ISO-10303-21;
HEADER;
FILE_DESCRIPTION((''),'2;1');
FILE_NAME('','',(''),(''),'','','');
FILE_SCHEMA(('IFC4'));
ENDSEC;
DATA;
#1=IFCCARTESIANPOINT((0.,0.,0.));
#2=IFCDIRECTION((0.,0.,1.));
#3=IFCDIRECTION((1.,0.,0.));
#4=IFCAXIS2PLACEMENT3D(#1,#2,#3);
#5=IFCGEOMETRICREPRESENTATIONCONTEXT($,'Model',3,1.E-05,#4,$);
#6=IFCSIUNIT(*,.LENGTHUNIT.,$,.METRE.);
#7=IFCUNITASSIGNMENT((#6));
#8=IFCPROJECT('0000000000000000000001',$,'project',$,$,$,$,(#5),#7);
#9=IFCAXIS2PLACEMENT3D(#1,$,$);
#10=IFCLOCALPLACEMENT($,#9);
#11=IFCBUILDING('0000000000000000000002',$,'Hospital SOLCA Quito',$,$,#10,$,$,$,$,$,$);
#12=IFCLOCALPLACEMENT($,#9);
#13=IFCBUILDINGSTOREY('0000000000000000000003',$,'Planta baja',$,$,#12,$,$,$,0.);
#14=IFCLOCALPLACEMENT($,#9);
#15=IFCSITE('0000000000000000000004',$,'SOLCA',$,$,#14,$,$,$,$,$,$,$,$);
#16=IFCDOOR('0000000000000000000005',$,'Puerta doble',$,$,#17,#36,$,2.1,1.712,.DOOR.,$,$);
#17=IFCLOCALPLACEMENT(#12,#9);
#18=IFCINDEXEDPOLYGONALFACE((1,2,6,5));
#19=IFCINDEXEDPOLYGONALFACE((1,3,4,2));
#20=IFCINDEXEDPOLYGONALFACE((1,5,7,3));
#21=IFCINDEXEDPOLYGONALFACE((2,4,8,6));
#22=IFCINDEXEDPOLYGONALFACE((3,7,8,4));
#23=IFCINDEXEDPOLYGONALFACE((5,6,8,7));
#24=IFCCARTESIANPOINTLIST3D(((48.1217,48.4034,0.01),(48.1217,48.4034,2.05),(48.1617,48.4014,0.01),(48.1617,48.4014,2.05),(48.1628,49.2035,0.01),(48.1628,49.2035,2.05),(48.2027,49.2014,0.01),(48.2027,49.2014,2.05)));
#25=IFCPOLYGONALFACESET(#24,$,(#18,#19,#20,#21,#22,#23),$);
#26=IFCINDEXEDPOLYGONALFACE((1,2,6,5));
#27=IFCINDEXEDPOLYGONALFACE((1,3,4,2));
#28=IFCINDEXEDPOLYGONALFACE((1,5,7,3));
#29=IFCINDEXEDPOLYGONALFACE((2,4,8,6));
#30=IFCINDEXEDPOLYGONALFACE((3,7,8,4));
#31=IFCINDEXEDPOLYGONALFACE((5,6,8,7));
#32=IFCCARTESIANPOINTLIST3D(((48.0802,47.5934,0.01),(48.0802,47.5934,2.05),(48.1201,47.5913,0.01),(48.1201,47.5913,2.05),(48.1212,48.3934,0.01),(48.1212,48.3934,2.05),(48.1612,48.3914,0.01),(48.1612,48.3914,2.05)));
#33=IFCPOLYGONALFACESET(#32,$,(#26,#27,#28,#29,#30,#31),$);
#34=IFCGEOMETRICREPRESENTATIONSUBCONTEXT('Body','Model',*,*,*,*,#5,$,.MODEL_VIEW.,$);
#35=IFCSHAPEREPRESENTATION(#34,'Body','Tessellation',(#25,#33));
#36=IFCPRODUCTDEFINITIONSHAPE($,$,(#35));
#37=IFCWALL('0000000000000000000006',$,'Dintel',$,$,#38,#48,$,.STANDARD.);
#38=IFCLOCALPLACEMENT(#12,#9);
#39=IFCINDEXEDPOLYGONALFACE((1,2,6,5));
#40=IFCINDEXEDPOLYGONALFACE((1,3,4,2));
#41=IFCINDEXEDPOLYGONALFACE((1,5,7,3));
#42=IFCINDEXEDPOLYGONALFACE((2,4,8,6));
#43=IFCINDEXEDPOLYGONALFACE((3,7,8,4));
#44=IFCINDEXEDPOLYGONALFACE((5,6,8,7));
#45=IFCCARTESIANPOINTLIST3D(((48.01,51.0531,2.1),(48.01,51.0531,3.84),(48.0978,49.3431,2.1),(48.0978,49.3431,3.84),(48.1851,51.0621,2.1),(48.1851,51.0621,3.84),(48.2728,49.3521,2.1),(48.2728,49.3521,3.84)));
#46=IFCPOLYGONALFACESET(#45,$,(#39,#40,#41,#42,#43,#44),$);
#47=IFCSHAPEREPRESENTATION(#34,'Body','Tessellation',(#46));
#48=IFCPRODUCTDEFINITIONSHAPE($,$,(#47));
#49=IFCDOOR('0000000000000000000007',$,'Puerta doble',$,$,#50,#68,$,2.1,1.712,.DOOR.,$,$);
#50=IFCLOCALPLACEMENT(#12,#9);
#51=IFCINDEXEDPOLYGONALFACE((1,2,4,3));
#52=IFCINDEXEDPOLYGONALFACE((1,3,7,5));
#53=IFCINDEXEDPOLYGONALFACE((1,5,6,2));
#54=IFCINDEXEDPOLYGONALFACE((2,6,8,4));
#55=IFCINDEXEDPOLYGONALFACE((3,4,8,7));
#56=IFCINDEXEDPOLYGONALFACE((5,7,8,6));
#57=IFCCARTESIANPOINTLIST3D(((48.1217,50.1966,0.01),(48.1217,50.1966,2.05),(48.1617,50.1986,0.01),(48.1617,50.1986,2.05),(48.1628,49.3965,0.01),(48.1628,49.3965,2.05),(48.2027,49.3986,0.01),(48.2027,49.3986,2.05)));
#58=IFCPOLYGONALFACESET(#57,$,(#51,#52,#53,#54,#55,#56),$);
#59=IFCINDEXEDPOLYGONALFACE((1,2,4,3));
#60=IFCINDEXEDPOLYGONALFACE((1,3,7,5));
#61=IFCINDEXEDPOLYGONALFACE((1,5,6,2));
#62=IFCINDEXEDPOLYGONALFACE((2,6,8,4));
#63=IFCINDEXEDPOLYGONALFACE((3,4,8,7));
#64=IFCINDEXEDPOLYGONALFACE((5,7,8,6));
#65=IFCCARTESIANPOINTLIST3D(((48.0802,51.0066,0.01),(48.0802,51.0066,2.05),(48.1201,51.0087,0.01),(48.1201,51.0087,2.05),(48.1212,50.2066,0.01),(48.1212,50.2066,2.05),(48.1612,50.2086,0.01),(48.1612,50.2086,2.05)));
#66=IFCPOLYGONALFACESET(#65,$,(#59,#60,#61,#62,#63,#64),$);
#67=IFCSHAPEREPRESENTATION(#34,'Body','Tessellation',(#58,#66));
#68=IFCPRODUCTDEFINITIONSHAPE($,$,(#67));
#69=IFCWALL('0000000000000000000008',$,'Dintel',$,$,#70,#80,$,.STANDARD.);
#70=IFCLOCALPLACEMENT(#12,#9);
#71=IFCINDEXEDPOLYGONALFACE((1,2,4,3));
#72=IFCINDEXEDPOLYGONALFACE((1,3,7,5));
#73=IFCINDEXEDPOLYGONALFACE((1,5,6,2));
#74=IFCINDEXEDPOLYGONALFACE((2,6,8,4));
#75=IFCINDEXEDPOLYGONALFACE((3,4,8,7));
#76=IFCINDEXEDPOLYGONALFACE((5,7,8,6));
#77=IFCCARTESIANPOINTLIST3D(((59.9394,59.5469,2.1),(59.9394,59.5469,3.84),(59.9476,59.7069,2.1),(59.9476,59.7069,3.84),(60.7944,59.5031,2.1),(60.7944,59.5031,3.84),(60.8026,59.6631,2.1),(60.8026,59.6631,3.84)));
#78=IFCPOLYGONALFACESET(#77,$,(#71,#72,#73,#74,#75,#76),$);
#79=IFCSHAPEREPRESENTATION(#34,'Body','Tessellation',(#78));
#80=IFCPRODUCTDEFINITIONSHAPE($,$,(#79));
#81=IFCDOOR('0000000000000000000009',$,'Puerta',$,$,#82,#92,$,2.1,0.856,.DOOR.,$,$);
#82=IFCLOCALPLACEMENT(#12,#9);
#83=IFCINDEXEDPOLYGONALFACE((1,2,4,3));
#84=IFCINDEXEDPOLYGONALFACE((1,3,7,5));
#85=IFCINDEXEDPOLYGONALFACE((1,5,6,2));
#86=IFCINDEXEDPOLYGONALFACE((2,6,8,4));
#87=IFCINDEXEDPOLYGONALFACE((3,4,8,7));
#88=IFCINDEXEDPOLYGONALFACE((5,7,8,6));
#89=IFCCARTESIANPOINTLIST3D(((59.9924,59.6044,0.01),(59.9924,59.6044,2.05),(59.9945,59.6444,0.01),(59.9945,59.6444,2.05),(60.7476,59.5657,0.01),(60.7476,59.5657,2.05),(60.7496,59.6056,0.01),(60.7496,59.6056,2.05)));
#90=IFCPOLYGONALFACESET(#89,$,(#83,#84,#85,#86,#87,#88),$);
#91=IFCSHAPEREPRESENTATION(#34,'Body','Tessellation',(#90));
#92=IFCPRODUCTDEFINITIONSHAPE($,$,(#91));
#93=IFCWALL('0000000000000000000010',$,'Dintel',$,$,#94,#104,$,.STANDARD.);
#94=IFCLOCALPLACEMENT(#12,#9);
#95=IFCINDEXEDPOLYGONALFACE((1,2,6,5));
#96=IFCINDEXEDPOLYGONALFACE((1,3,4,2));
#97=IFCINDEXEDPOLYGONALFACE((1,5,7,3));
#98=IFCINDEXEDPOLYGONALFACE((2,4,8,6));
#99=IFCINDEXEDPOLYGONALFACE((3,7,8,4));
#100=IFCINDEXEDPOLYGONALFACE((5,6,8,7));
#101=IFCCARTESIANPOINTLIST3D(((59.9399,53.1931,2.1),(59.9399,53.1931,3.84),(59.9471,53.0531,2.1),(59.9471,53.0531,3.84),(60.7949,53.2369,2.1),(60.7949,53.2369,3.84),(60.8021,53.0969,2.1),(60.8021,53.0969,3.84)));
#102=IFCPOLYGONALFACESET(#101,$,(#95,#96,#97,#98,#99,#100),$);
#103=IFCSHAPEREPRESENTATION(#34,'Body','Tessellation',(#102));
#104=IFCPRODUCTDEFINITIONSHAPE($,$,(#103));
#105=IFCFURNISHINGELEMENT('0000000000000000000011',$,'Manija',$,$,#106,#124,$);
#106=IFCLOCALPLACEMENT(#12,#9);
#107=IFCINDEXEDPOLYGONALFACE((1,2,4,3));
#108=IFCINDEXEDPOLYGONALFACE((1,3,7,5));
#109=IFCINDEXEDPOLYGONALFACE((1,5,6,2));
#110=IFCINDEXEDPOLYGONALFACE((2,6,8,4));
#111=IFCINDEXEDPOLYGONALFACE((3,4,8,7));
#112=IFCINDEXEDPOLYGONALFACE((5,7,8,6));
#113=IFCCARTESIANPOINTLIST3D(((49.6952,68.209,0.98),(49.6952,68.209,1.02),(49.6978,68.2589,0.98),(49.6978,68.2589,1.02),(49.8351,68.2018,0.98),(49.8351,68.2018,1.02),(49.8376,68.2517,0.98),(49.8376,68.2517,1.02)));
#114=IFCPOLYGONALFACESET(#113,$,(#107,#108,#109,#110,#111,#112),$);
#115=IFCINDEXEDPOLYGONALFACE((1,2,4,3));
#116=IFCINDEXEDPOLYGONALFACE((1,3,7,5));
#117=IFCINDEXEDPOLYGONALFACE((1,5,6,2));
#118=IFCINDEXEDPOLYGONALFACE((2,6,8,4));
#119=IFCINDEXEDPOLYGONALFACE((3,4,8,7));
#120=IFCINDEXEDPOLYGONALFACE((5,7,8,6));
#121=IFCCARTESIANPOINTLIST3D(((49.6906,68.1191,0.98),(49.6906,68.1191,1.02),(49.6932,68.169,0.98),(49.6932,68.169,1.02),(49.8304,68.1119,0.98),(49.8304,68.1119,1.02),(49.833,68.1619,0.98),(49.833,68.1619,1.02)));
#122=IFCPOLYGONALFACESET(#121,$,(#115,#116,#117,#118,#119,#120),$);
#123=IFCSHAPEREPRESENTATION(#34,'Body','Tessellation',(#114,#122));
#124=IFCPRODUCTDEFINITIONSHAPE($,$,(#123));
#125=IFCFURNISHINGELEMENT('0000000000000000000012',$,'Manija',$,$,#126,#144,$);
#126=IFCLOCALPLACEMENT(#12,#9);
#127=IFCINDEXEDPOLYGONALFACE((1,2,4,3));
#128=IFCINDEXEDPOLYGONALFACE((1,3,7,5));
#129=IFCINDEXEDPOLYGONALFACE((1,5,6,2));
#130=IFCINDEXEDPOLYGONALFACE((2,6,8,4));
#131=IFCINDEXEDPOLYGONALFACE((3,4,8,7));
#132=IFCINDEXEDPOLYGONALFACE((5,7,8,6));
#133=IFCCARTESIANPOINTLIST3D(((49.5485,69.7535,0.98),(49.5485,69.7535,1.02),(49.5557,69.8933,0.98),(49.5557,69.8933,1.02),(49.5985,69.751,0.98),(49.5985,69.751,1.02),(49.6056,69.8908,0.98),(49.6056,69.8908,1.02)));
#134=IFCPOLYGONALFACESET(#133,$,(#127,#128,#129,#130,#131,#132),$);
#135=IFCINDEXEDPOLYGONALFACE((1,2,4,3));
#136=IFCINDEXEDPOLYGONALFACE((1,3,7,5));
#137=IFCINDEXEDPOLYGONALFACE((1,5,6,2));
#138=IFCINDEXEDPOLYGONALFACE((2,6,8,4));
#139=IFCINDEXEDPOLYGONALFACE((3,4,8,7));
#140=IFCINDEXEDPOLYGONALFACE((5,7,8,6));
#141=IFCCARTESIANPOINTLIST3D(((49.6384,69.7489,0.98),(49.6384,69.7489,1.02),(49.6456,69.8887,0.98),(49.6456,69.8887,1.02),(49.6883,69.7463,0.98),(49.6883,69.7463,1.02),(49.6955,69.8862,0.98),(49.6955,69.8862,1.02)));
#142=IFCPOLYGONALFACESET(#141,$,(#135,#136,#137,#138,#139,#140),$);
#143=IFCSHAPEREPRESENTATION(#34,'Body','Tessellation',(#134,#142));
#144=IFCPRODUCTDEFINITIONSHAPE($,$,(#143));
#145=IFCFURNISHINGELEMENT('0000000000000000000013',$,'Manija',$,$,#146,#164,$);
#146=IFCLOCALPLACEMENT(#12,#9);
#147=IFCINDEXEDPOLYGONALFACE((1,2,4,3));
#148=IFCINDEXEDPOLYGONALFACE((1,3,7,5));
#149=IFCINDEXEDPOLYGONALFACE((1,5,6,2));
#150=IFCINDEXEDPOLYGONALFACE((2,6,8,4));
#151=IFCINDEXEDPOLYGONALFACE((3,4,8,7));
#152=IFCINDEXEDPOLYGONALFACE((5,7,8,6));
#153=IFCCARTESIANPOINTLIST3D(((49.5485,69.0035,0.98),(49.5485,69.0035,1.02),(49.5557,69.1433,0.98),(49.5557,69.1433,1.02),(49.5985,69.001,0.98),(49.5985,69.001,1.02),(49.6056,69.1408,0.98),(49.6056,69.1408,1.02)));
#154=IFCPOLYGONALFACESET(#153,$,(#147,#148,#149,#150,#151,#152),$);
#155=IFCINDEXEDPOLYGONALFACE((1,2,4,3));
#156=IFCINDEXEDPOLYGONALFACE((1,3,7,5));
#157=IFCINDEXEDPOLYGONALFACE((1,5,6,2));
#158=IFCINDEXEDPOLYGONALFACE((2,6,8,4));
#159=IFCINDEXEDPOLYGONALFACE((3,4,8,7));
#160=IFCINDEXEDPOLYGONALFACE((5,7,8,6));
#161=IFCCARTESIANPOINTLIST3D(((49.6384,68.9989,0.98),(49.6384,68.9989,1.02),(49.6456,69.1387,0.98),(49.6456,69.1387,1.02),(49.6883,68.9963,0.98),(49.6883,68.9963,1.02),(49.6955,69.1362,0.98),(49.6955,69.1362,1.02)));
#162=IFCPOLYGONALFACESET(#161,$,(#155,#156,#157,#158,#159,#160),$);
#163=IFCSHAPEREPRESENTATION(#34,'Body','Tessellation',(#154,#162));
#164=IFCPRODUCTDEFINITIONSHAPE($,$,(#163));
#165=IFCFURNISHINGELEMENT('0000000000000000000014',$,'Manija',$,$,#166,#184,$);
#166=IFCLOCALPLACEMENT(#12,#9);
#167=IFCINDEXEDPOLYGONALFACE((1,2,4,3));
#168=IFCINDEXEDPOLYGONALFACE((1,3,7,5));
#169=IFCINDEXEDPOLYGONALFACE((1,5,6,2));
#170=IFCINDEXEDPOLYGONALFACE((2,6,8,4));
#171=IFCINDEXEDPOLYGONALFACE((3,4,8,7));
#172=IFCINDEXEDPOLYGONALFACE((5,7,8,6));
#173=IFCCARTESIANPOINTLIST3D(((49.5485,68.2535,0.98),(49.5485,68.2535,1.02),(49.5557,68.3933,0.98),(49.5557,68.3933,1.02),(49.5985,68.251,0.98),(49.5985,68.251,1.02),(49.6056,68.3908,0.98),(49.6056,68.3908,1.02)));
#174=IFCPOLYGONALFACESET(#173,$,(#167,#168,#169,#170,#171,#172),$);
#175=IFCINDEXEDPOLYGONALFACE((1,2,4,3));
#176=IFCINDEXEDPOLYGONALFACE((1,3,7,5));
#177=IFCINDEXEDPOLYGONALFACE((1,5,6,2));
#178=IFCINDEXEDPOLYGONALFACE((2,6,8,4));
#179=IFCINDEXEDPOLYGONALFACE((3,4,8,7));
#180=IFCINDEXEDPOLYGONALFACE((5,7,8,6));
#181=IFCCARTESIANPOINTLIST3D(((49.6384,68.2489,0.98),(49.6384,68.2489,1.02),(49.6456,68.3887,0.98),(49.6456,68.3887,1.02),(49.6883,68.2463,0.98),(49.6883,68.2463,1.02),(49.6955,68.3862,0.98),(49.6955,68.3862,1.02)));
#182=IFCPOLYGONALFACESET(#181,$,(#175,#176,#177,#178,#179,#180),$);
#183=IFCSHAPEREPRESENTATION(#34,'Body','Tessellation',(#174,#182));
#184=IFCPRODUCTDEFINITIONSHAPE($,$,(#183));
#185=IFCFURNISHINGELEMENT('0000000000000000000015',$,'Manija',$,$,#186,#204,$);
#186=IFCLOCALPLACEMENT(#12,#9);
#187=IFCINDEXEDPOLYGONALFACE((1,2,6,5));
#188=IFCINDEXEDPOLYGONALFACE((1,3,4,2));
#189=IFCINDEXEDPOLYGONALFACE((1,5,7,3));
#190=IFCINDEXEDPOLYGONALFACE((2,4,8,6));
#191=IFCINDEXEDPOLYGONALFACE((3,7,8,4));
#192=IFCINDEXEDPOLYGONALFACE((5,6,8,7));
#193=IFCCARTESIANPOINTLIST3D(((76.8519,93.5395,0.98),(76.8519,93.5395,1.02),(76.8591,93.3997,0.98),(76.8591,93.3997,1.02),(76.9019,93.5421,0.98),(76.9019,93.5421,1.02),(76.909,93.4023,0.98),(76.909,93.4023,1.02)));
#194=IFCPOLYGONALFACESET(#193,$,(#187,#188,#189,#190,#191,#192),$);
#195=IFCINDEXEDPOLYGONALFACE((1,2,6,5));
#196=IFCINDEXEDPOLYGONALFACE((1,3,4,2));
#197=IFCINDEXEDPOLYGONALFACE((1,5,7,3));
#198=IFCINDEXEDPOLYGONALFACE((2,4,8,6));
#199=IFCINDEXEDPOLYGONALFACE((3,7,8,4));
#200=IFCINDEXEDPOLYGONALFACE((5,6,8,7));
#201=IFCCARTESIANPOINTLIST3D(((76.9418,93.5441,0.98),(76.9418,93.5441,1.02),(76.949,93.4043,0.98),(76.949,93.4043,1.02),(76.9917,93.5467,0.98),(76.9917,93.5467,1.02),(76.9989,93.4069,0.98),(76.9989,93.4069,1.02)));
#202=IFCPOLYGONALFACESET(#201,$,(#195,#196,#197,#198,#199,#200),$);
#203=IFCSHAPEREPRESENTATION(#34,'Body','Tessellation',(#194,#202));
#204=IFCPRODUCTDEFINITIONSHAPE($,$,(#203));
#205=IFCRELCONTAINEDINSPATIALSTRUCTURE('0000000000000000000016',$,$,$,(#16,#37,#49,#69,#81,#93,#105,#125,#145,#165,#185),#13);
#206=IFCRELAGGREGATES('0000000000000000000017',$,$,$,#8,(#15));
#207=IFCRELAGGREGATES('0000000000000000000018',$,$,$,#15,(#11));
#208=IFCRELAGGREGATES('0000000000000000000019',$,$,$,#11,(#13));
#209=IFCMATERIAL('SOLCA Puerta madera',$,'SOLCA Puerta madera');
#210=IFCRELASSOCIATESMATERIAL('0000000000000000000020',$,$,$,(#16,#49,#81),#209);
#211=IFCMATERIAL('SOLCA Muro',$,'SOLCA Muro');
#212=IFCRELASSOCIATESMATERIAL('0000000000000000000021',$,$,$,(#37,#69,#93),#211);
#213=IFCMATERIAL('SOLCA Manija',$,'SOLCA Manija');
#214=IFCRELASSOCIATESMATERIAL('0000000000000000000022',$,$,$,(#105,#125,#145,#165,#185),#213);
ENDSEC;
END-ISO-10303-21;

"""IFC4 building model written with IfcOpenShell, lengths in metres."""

from ifc_helpers import new_model, si_unit, frame, origin, origin_with_axes, place, context, subcontext, project, spatial, polyline, outline, extrude, material, element, save


model = new_model("IFC4")

# Units and contexts
model_context = context("Model", 3, precision=1e-05, world=origin_with_axes())
body_context = subcontext(model_context, "Body", "Model", "MODEL_VIEW")
ifc_project = project(units=[si_unit("LENGTHUNIT", "METRE")], contexts=[model_context])

# Site, building, storey
site_placement = place(None, origin())
site = spatial("IfcSite", under=ifc_project, at=site_placement, Name="SOLCA")
building_placement = place(None, origin())
building = spatial("IfcBuilding", under=site, at=building_placement, Name="Hospital SOLCA Quito")
storey_placement = place(None, origin())
storey = spatial("IfcBuildingStorey", under=building, at=storey_placement, Name="Planta baja", Elevation=0.0)

# Shared definitions
ifc_material_1 = material(Name="SOLCA Muro", Category="SOLCA Muro")

# Shared definitions
ifc_material_2 = material(Name="SOLCA Puerta madera", Category="SOLCA Puerta madera")

# Door
door_1_placement = place(storey_placement, origin_with_axes())
element("IfcDoor", 1, at=door_1_placement, inside=storey, material=ifc_material_2, Name="Puerta doble", OverallHeight=2.1, OverallWidth=1.712, PredefinedType="DOOR", context=body_context, shape_type="SweptSolid", body=[
    extrude(outline(polyline([(48.1628, 49.2035), (48.1217, 48.4034), (48.1617, 48.4014), (48.2027, 49.2014), (48.1628, 49.2035)])), frame((0.0, 0.0, 0.01), z_axis=(0.0, 0.0, 1.0), x_axis=(1.0, 0.0, 0.0)), (0.0, 0.0, 1.0), 2.04),
    extrude(outline(polyline([(48.1212, 48.3934), (48.0802, 47.5934), (48.1201, 47.5913), (48.1612, 48.3914), (48.1212, 48.3934)])), frame((0.0, 0.0, 0.01), z_axis=(0.0, 0.0, 1.0), x_axis=(1.0, 0.0, 0.0)), (0.0, 0.0, 1.0), 2.04),
])

# Wall
wall_1_placement = place(storey_placement, origin_with_axes())
element("IfcWall", 2, at=wall_1_placement, inside=storey, material=ifc_material_1, Name="Dintel", PredefinedType="STANDARD", context=body_context, shape_type="SweptSolid", body=[
    extrude(outline(polyline([(48.2728, 49.3521), (48.1851, 51.0621), (48.01, 51.0531), (48.0978, 49.3431), (48.2728, 49.3521)])), frame((0.0, 0.0, 2.1), z_axis=(0.0, 0.0, 1.0), x_axis=(1.0, 0.0, 0.0)), (0.0, 0.0, 1.0), 1.74),
])

# Door
door_2_placement = place(storey_placement, origin_with_axes())
element("IfcDoor", 3, at=door_2_placement, inside=storey, material=ifc_material_2, Name="Puerta doble", OverallHeight=2.1, OverallWidth=1.712, PredefinedType="DOOR", context=body_context, shape_type="SweptSolid", body=[
    extrude(outline(polyline([(48.2027, 49.3986), (48.1617, 50.1986), (48.1217, 50.1966), (48.1628, 49.3965), (48.2027, 49.3986)])), frame((0.0, 0.0, 0.01), z_axis=(0.0, 0.0, 1.0), x_axis=(1.0, 0.0, 0.0)), (0.0, 0.0, 1.0), 2.04),
    extrude(outline(polyline([(48.1612, 50.2086), (48.1201, 51.0087), (48.0802, 51.0066), (48.1212, 50.2066), (48.1612, 50.2086)])), frame((0.0, 0.0, 0.01), z_axis=(0.0, 0.0, 1.0), x_axis=(1.0, 0.0, 0.0)), (0.0, 0.0, 1.0), 2.04),
])

# Wall
wall_2_placement = place(storey_placement, origin_with_axes())
element("IfcWall", 4, at=wall_2_placement, inside=storey, material=ifc_material_1, Name="Dintel", PredefinedType="STANDARD", context=body_context, shape_type="SweptSolid", body=[
    extrude(outline(polyline([(60.8026, 59.6631), (59.9476, 59.7069), (59.9394, 59.5469), (60.7944, 59.5031), (60.8026, 59.6631)])), frame((0.0, 0.0, 2.1), z_axis=(0.0, 0.0, 1.0), x_axis=(1.0, 0.0, 0.0)), (0.0, 0.0, 1.0), 1.74),
])

# Door
door_3_placement = place(storey_placement, origin_with_axes())
element("IfcDoor", 5, at=door_3_placement, inside=storey, material=ifc_material_2, Name="Puerta", OverallHeight=2.1, OverallWidth=0.856, PredefinedType="DOOR", context=body_context, shape_type="SweptSolid", body=[
    extrude(outline(polyline([(60.7496, 59.6056), (59.9945, 59.6444), (59.9924, 59.6044), (60.7476, 59.5657), (60.7496, 59.6056)])), frame((0.0, 0.0, 0.01), z_axis=(0.0, 0.0, 1.0), x_axis=(1.0, 0.0, 0.0)), (0.0, 0.0, 1.0), 2.04),
])

# Wall
wall_3_placement = place(storey_placement, origin_with_axes())
element("IfcWall", 6, at=wall_3_placement, inside=storey, material=ifc_material_1, Name="Dintel", PredefinedType="STANDARD", context=body_context, shape_type="SweptSolid", body=[
    extrude(outline(polyline([(60.7949, 53.2369), (59.9399, 53.1931), (59.9471, 53.0531), (60.8021, 53.0969), (60.7949, 53.2369)])), frame((0.0, 0.0, 2.1), z_axis=(0.0, 0.0, 1.0), x_axis=(1.0, 0.0, 0.0)), (0.0, 0.0, 1.0), 1.74),
])

# Furnishing elements
ifc_material_3 = material(Name="SOLCA Manija", Category="SOLCA Manija")
furnishing_1_placement = place(storey_placement, origin_with_axes())
element("IfcFurnishingElement", 7, at=furnishing_1_placement, inside=storey, material=ifc_material_3, Name="Manija", context=body_context, shape_type="SweptSolid", body=[
    extrude(outline(polyline([(49.8376, 68.2517), (49.6978, 68.2589), (49.6952, 68.209), (49.8351, 68.2018), (49.8376, 68.2517)])), frame((0.0, 0.0, 0.98), z_axis=(0.0, 0.0, 1.0), x_axis=(1.0, 0.0, 0.0)), (0.0, 0.0, 1.0), 0.04),
    extrude(outline(polyline([(49.833, 68.1619), (49.6932, 68.169), (49.6906, 68.1191), (49.8304, 68.1119), (49.833, 68.1619)])), frame((0.0, 0.0, 0.98), z_axis=(0.0, 0.0, 1.0), x_axis=(1.0, 0.0, 0.0)), (0.0, 0.0, 1.0), 0.04),
])
furnishing_2_placement = place(storey_placement, origin_with_axes())
element("IfcFurnishingElement", 8, at=furnishing_2_placement, inside=storey, material=ifc_material_3, Name="Manija", context=body_context, shape_type="SweptSolid", body=[
    extrude(outline(polyline([(49.5557, 69.8933), (49.5485, 69.7535), (49.5985, 69.751), (49.6056, 69.8908), (49.5557, 69.8933)])), frame((0.0, 0.0, 0.98), z_axis=(0.0, 0.0, 1.0), x_axis=(1.0, 0.0, 0.0)), (0.0, 0.0, 1.0), 0.04),
    extrude(outline(polyline([(49.6456, 69.8887), (49.6384, 69.7489), (49.6883, 69.7463), (49.6955, 69.8862), (49.6456, 69.8887)])), frame((0.0, 0.0, 0.98), z_axis=(0.0, 0.0, 1.0), x_axis=(1.0, 0.0, 0.0)), (0.0, 0.0, 1.0), 0.04),
])
furnishing_3_placement = place(storey_placement, origin_with_axes())
element("IfcFurnishingElement", 9, at=furnishing_3_placement, inside=storey, material=ifc_material_3, Name="Manija", context=body_context, shape_type="SweptSolid", body=[
    extrude(outline(polyline([(49.5557, 69.1433), (49.5485, 69.0035), (49.5985, 69.001), (49.6056, 69.1408), (49.5557, 69.1433)])), frame((0.0, 0.0, 0.98), z_axis=(0.0, 0.0, 1.0), x_axis=(1.0, 0.0, 0.0)), (0.0, 0.0, 1.0), 0.04),
    extrude(outline(polyline([(49.6456, 69.1387), (49.6384, 68.9989), (49.6883, 68.9963), (49.6955, 69.1362), (49.6456, 69.1387)])), frame((0.0, 0.0, 0.98), z_axis=(0.0, 0.0, 1.0), x_axis=(1.0, 0.0, 0.0)), (0.0, 0.0, 1.0), 0.04),
])
furnishing_4_placement = place(storey_placement, origin_with_axes())
element("IfcFurnishingElement", 10, at=furnishing_4_placement, inside=storey, material=ifc_material_3, Name="Manija", context=body_context, shape_type="SweptSolid", body=[
    extrude(outline(polyline([(49.5557, 68.3933), (49.5485, 68.2535), (49.5985, 68.251), (49.6056, 68.3908), (49.5557, 68.3933)])), frame((0.0, 0.0, 0.98), z_axis=(0.0, 0.0, 1.0), x_axis=(1.0, 0.0, 0.0)), (0.0, 0.0, 1.0), 0.04),
    extrude(outline(polyline([(49.6456, 68.3887), (49.6384, 68.2489), (49.6883, 68.2463), (49.6955, 68.3862), (49.6456, 68.3887)])), frame((0.0, 0.0, 0.98), z_axis=(0.0, 0.0, 1.0), x_axis=(1.0, 0.0, 0.0)), (0.0, 0.0, 1.0), 0.04),
])
furnishing_5_placement = place(storey_placement, origin_with_axes())
element("IfcFurnishingElement", 11, at=furnishing_5_placement, inside=storey, material=ifc_material_3, Name="Manija", context=body_context, shape_type="SweptSolid", body=[
    extrude(outline(polyline([(76.8519, 93.5395), (76.8591, 93.3997), (76.909, 93.4023), (76.9019, 93.5421), (76.8519, 93.5395)])), frame((0.0, 0.0, 0.98), z_axis=(0.0, 0.0, 1.0), x_axis=(1.0, 0.0, 0.0)), (0.0, 0.0, 1.0), 0.04),
    extrude(outline(polyline([(76.9418, 93.5441), (76.949, 93.4043), (76.9989, 93.4069), (76.9917, 93.5467), (76.9418, 93.5441)])), frame((0.0, 0.0, 0.98), z_axis=(0.0, 0.0, 1.0), x_axis=(1.0, 0.0, 0.0)), (0.0, 0.0, 1.0), 0.04),
])

save(model, "model.ifc")
